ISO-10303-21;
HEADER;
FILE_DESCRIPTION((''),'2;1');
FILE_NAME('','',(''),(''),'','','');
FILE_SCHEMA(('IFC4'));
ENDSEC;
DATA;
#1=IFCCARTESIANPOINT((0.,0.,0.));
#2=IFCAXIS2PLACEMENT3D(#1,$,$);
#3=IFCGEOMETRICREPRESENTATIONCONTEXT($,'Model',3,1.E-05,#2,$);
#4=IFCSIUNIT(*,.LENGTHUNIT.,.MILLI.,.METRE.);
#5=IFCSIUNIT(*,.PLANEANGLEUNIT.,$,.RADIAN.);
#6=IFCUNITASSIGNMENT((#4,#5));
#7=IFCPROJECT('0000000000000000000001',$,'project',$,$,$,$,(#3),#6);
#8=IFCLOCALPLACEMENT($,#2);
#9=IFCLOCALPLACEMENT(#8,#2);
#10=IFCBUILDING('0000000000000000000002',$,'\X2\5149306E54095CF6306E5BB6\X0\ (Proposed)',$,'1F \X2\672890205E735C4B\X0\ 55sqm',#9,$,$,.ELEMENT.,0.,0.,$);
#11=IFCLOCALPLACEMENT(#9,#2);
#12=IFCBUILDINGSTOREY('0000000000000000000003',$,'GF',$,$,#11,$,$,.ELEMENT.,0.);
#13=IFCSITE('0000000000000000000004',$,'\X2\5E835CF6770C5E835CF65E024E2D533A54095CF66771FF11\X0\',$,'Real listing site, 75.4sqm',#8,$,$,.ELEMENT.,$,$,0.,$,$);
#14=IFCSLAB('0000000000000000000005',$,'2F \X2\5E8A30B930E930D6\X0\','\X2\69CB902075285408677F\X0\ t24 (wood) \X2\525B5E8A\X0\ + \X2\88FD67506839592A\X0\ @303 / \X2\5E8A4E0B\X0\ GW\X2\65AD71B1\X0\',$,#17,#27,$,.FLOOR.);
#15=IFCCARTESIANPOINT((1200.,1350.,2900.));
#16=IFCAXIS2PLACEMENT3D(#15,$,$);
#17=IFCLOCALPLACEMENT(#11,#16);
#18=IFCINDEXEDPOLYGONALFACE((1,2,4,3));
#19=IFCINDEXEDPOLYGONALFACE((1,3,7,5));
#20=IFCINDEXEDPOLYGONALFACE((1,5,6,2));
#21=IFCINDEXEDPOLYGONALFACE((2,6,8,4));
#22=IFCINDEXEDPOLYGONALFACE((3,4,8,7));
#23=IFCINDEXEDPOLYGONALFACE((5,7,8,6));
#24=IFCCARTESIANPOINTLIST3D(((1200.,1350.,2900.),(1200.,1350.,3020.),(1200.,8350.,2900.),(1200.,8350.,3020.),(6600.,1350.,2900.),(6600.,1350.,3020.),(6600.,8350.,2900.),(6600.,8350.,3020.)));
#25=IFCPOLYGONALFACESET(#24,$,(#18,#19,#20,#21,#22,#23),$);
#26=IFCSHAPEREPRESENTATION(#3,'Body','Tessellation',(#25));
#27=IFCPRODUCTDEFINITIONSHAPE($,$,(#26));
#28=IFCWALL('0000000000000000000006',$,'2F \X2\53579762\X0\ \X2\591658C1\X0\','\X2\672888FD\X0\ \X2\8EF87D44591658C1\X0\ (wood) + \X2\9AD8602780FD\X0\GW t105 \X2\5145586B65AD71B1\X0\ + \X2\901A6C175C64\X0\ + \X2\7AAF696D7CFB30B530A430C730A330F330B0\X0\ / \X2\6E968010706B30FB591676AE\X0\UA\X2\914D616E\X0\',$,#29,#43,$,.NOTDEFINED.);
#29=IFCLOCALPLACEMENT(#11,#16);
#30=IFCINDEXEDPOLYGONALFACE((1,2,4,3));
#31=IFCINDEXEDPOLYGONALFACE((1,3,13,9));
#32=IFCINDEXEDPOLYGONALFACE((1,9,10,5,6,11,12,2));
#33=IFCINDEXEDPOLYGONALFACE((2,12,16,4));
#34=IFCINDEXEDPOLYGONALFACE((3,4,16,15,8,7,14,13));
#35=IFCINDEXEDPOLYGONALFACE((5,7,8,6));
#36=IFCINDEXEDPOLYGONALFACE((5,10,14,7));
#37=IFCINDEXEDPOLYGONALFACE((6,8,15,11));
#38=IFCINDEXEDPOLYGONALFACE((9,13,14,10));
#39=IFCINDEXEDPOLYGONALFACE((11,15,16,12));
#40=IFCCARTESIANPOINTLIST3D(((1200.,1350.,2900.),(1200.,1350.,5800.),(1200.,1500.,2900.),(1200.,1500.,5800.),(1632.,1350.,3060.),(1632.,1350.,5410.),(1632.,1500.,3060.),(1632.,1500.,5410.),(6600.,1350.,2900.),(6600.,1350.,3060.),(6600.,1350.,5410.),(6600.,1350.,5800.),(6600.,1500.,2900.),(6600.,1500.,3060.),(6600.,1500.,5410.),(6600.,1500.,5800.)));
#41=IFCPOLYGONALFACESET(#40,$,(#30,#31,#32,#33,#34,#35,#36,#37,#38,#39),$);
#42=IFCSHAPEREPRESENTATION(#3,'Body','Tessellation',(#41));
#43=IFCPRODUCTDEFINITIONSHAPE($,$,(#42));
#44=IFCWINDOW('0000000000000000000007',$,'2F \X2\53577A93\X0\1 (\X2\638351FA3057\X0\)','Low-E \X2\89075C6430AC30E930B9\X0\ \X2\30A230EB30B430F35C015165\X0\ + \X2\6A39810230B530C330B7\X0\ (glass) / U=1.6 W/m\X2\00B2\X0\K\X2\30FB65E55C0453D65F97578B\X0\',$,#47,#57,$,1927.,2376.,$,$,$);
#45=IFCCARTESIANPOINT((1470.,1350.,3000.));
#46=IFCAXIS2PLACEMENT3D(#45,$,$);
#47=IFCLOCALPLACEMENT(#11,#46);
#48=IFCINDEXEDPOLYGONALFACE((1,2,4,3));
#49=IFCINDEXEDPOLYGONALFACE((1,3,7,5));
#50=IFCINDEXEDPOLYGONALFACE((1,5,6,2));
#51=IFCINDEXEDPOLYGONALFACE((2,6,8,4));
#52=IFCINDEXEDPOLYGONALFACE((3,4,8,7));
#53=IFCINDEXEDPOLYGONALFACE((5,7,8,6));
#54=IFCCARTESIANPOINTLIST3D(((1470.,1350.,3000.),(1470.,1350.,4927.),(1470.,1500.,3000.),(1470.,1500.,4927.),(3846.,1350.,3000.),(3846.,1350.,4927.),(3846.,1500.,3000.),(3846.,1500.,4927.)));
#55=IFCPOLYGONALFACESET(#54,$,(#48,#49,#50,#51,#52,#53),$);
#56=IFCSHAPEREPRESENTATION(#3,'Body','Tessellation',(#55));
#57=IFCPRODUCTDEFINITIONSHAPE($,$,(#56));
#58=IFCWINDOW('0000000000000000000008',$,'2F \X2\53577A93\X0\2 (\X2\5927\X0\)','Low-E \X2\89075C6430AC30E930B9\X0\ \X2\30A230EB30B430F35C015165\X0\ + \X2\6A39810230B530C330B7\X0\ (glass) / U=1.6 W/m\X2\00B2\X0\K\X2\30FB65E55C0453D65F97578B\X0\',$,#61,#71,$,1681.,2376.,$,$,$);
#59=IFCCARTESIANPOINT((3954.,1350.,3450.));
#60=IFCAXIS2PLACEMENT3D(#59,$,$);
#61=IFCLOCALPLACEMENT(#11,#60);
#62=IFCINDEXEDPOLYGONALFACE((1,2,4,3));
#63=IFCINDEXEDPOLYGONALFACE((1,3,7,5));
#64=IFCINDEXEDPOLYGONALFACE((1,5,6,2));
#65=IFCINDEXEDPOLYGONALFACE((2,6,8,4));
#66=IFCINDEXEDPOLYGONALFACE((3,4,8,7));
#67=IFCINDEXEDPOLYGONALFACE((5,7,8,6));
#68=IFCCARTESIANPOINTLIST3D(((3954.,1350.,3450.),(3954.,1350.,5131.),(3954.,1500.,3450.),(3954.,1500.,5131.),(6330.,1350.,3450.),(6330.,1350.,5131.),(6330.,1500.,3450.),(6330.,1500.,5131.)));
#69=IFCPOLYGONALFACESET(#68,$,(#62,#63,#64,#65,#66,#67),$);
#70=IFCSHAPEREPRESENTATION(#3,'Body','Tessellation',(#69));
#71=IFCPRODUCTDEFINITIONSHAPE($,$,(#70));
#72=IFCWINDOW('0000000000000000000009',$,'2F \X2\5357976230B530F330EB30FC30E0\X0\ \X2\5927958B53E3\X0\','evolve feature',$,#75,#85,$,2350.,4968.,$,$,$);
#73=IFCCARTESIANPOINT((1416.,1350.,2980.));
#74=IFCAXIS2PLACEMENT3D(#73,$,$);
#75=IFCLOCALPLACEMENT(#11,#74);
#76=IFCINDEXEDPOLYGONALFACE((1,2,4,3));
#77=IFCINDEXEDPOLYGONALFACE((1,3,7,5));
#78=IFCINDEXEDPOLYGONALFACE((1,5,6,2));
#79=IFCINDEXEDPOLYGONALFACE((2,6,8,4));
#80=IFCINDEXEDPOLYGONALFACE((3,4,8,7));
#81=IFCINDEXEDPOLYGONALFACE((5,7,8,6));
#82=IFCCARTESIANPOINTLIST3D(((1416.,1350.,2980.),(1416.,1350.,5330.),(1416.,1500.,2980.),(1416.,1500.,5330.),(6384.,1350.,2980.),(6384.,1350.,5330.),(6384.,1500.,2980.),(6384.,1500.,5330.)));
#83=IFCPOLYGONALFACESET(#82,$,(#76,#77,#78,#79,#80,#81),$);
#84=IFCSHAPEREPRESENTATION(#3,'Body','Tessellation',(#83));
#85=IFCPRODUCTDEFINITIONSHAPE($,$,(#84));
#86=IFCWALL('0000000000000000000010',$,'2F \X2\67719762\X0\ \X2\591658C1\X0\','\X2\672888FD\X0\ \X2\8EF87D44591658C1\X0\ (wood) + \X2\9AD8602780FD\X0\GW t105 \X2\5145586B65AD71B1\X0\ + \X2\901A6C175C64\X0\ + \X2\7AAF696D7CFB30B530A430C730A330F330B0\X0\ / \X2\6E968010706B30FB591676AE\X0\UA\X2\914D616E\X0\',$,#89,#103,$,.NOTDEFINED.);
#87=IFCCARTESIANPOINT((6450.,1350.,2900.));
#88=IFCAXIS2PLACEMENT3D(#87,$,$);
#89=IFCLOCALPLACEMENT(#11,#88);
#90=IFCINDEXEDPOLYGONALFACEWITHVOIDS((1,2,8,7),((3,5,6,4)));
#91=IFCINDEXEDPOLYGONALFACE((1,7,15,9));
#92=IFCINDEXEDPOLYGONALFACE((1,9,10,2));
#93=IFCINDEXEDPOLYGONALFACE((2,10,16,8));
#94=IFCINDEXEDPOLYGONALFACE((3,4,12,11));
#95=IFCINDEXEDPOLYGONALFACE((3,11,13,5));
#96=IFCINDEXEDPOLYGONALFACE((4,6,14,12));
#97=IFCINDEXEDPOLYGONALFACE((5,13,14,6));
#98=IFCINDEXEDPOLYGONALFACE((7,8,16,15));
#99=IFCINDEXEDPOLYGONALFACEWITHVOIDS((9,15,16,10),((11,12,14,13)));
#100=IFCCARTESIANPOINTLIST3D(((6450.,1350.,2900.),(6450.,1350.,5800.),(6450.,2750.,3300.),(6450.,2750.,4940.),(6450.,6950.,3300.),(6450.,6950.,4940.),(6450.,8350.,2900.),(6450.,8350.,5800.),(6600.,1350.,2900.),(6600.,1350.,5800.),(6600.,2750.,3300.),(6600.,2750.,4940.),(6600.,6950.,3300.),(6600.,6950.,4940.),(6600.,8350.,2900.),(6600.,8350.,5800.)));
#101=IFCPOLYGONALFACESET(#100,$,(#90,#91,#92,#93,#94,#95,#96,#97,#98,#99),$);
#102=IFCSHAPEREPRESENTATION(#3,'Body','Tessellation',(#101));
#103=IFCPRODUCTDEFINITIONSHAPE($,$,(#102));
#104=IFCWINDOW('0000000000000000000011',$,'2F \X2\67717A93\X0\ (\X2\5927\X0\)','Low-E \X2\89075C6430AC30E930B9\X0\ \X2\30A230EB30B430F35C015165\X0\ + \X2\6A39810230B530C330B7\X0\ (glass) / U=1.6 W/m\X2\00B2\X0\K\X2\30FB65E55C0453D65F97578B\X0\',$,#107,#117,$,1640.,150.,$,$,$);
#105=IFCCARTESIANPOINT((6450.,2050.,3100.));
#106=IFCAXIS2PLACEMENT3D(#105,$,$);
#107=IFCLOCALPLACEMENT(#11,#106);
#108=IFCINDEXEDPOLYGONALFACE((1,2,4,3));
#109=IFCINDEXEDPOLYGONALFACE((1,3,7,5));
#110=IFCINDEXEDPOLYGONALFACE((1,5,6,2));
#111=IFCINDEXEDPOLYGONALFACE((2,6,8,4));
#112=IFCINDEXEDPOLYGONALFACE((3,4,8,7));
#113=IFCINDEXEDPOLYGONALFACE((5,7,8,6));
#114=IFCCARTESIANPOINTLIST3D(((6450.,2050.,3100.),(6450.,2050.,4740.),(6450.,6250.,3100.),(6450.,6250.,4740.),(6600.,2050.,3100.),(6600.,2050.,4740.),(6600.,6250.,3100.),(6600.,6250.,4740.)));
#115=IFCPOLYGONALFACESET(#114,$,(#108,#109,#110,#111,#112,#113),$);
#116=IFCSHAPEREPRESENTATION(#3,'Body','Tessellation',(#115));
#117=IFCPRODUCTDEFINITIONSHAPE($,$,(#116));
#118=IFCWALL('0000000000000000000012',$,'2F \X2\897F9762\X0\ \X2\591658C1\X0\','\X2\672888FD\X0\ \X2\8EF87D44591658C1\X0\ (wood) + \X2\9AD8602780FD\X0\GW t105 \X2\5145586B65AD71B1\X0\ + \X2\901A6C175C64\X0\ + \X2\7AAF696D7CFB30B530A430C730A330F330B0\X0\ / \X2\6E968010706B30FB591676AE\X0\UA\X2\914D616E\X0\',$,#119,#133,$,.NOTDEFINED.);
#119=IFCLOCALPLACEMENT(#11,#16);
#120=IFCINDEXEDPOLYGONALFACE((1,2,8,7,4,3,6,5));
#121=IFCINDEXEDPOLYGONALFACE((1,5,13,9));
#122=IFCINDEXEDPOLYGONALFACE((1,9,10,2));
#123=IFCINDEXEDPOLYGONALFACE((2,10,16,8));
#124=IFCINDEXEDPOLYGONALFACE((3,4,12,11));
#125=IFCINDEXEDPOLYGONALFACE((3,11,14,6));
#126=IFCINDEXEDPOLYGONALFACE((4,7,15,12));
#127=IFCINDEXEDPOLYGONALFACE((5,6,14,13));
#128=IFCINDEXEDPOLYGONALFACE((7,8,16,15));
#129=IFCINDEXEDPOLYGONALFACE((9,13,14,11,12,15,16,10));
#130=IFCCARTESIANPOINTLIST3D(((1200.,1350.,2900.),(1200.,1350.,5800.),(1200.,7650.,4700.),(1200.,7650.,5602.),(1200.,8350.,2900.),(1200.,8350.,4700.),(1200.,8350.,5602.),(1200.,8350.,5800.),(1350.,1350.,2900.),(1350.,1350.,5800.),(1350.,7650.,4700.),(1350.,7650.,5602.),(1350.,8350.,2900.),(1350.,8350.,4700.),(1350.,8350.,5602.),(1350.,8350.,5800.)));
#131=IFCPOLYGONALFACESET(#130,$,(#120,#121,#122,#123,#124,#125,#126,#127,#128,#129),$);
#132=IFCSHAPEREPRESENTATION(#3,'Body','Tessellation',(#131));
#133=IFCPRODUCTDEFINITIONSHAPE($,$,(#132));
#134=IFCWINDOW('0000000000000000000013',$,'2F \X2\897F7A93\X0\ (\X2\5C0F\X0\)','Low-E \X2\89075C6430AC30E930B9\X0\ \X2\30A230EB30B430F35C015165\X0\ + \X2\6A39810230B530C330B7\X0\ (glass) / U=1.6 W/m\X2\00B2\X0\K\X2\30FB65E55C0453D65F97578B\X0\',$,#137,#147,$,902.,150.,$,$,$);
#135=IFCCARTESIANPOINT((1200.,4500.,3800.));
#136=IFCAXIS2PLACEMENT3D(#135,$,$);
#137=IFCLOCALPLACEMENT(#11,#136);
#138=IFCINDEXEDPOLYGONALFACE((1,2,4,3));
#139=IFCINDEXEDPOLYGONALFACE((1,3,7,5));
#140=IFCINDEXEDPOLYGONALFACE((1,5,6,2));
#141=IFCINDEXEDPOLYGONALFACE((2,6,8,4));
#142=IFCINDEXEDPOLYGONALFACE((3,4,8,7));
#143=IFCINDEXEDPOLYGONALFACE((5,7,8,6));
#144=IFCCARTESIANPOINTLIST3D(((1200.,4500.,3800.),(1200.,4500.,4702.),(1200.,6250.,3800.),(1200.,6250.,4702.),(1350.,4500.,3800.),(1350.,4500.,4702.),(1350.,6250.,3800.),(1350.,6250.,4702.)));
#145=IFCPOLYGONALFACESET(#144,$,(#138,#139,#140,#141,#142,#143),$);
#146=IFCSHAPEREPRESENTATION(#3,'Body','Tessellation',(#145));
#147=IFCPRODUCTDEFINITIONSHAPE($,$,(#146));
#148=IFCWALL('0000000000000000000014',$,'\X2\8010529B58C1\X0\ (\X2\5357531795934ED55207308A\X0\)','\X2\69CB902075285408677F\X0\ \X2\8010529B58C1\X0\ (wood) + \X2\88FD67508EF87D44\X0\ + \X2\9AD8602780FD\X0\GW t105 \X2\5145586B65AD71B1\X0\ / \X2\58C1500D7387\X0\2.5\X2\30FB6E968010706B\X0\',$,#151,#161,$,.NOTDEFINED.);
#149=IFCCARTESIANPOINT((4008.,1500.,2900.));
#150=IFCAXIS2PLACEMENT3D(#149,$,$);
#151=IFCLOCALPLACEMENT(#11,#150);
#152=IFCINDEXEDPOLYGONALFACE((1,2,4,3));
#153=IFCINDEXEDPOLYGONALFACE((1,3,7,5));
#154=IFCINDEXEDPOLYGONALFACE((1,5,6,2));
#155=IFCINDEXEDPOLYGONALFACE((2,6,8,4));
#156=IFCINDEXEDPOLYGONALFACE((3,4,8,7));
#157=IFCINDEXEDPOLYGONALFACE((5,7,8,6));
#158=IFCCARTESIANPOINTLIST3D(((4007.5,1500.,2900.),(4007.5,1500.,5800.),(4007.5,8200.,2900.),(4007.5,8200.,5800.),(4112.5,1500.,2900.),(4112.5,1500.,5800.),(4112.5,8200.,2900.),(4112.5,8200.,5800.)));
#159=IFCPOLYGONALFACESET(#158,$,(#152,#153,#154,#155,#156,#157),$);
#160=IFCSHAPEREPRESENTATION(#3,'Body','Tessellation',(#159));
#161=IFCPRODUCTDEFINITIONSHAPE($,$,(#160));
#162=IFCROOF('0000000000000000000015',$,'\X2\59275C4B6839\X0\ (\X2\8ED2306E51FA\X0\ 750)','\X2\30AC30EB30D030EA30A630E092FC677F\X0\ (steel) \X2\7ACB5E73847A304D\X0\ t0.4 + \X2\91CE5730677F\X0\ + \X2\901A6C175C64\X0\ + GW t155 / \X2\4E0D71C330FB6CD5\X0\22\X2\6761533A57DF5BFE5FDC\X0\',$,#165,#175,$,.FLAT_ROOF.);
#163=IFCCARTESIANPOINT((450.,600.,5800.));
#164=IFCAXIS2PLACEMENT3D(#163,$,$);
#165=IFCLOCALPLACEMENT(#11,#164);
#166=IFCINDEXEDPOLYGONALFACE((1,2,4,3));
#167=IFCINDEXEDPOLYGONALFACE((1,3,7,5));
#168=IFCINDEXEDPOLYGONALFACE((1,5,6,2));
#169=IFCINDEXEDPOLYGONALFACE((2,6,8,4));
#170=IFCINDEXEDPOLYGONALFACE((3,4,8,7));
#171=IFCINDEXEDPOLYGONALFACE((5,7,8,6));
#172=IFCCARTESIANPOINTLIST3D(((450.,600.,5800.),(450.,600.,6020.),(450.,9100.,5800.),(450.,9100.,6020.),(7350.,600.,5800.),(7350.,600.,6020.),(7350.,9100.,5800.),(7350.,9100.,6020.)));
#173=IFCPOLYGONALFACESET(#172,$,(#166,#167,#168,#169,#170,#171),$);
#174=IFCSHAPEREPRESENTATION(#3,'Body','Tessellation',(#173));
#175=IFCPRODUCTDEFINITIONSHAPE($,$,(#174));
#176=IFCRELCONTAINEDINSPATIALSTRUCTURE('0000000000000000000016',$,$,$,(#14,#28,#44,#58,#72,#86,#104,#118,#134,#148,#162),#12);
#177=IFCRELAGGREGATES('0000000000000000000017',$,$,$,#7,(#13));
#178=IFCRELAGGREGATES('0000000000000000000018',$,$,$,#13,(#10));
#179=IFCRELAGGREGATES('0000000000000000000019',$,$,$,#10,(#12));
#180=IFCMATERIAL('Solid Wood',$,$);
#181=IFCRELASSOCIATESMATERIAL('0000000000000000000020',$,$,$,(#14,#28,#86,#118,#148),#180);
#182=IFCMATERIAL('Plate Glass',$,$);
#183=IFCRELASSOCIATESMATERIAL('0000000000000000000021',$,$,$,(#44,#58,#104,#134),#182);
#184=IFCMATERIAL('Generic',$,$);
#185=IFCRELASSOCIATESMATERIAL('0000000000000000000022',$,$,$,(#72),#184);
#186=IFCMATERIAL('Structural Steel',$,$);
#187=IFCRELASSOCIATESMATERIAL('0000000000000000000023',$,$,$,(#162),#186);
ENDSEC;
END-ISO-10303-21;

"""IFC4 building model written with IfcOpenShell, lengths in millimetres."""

from ifc_helpers import new_model, si_unit, frame, frame_2d, origin, place, context, project, spatial, rectangle, extrude, material, element, fill, save


model = new_model("IFC4")

# Units and contexts
model_context = context("Model", 3, precision=1e-05, world=origin())
ifc_project = project(units=[si_unit("LENGTHUNIT", "METRE", prefix="MILLI"), si_unit("PLANEANGLEUNIT", "RADIAN")], contexts=[model_context])

# Site, building, storey
site_placement = place(None, origin())
site = spatial("IfcSite", under=ifc_project, at=site_placement, Name="広島県広島市中区吉島東１", ObjectType="Real listing site, 75.4sqm", CompositionType="ELEMENT", RefElevation=0.0)
building_placement = place(site_placement, origin())
building = spatial("IfcBuilding", under=site, at=building_placement, Name="光の吉島の家 (Proposed)", ObjectType="1F 木造平屋 55sqm", CompositionType="ELEMENT", ElevationOfRefHeight=0.0, ElevationOfTerrain=0.0)
storey_placement = place(building_placement, origin())
storey = spatial("IfcBuildingStorey", under=building, at=storey_placement, Name="GF", CompositionType="ELEMENT", Elevation=0.0)

# Slab
ifc_material_1 = material(Name="Solid Wood")
slab_placement = place(storey_placement, frame((1200.0, 1350.0, 2900.0)))
element("IfcSlab", 1, at=slab_placement, inside=storey, material=ifc_material_1, Name="2F 床スラブ", Description="構造用合板 t24 (wood) 剛床 + 製材根太 @303 / 床下 GW断熱", PredefinedType="FLOOR", context=model_context, shape_type="SweptSolid", body=[
    extrude(rectangle(XDim=5400.0, YDim=7000.0, at=frame_2d((2700.0, 3500.0))), frame((1200.0, 1350.0, 2900.0)), (0.0, 0.0, 1.0), 120.0),
])

# Wall, openings, windows
wall_1_placement = place(storey_placement, frame((1200.0, 1350.0, 2900.0)))
wall_1 = element("IfcWall", 2, at=wall_1_placement, inside=storey, material=ifc_material_1, Name="2F 南面 外壁", Description="木製 軸組外壁 (wood) + 高性能GW t105 充填断熱 + 通気層 + 窯業系サイディング / 準耐火・外皮UA配慮", PredefinedType="NOTDEFINED", context=model_context, shape_type="SweptSolid", body=[
    extrude(rectangle(XDim=5400.0, YDim=150.0, at=frame_2d((2700.0, 75.0))), frame((1200.0, 1350.0, 2900.0)), (0.0, 0.0, 1.0), 2900.0),
])
opening_1_placement = place(storey_placement, frame((1470.0, 1350.0, 3000.0)))
opening_1 = element("IfcOpeningElement", 3, at=opening_1_placement, cuts=wall_1, PredefinedType="NOTDEFINED", context=model_context, shape_type="SweptSolid", body=[
    extrude(rectangle(XDim=2376.0, YDim=150.0, at=frame_2d((1188.0, 75.0))), frame((1470.0, 1350.0, 3000.0)), (0.0, 0.0, 1.0), 1927.0),
])
opening_2_placement = place(storey_placement, frame((3954.0, 1350.0, 3450.0)))
opening_2 = element("IfcOpeningElement", 4, at=opening_2_placement, cuts=wall_1, PredefinedType="NOTDEFINED", context=model_context, shape_type="SweptSolid", body=[
    extrude(rectangle(XDim=2376.0, YDim=150.0, at=frame_2d((1188.0, 75.0))), frame((3954.0, 1350.0, 3450.0)), (0.0, 0.0, 1.0), 1681.0),
])
opening_3_placement = place(storey_placement, frame((1416.0, 1350.0, 2980.0)))
opening_3 = element("IfcOpeningElement", 5, at=opening_3_placement, cuts=wall_1, PredefinedType="NOTDEFINED", context=model_context, shape_type="SweptSolid", body=[
    extrude(rectangle(XDim=4968.0, YDim=150.0, at=frame_2d((2484.0, 75.0))), frame((1416.0, 1350.0, 2980.0)), (0.0, 0.0, 1.0), 2350.0),
])
ifc_material_2 = material(Name="Plate Glass")
window_1_placement = place(storey_placement, frame((1470.0, 1350.0, 3000.0)))
window_1 = element("IfcWindow", 6, at=window_1_placement, inside=storey, material=ifc_material_2, Name="2F 南窓1 (掃出し)", Description="Low-E 複層ガラス アルゴン封入 + 樹脂サッシ (glass) / U=1.6 W/m²K・日射取得型", OverallHeight=1927.0, OverallWidth=2376.0, context=model_context, shape_type="SweptSolid", body=[
    extrude(rectangle(XDim=2376.0, YDim=150.0, at=frame_2d((1188.0, 75.0))), frame((1470.0, 1350.0, 3000.0)), (0.0, 0.0, 1.0), 1927.0),
])
fill(opening_1, window_1)
window_2_placement = place(storey_placement, frame((3954.0, 1350.0, 3450.0)))
window_2 = element("IfcWindow", 7, at=window_2_placement, inside=storey, material=ifc_material_2, Name="2F 南窓2 (大)", Description="Low-E 複層ガラス アルゴン封入 + 樹脂サッシ (glass) / U=1.6 W/m²K・日射取得型", OverallHeight=1681.0, OverallWidth=2376.0, context=model_context, shape_type="SweptSolid", body=[
    extrude(rectangle(XDim=2376.0, YDim=150.0, at=frame_2d((1188.0, 75.0))), frame((3954.0, 1350.0, 3450.0)), (0.0, 0.0, 1.0), 1681.0),
])
fill(opening_2, window_2)
ifc_material_3 = material(Name="Generic")
window_3_placement = place(storey_placement, frame((1416.0, 1350.0, 2980.0)))
window_3 = element("IfcWindow", 8, at=window_3_placement, inside=storey, material=ifc_material_3, Name="2F 南面サンルーム 大開口", Description="evolve feature", OverallHeight=2350.0, OverallWidth=4968.0, context=model_context, shape_type="SweptSolid", body=[
    extrude(rectangle(XDim=4968.0, YDim=150.0, at=frame_2d((2484.0, 75.0))), frame((1416.0, 1350.0, 2980.0)), (0.0, 0.0, 1.0), 2350.0),
])
fill(opening_3, window_3)

# Walls, openings, windows
wall_2_placement = place(storey_placement, frame((6450.0, 1350.0, 2900.0)))
wall_2 = element("IfcWall", 9, at=wall_2_placement, inside=storey, material=ifc_material_1, Name="2F 東面 外壁", Description="木製 軸組外壁 (wood) + 高性能GW t105 充填断熱 + 通気層 + 窯業系サイディング / 準耐火・外皮UA配慮", PredefinedType="NOTDEFINED", context=model_context, shape_type="SweptSolid", body=[
    extrude(rectangle(XDim=150.0, YDim=7000.0, at=frame_2d((75.0, 3500.0))), frame((6450.0, 1350.0, 2900.0)), (0.0, 0.0, 1.0), 2900.0),
])
opening_4_placement = place(storey_placement, frame((6450.0, 2050.0, 3100.0)))
opening_4 = element("IfcOpeningElement", 10, at=opening_4_placement, cuts=wall_2, PredefinedType="NOTDEFINED", context=model_context, shape_type="SweptSolid", body=[
    extrude(rectangle(XDim=150.0, YDim=4200.0, at=frame_2d((75.0, 2100.0))), frame((6450.0, 2050.0, 3100.0)), (0.0, 0.0, 1.0), 1640.0),
])
window_4_placement = place(storey_placement, frame((6450.0, 2050.0, 3100.0)))
window_4 = element("IfcWindow", 11, at=window_4_placement, inside=storey, material=ifc_material_2, Name="2F 東窓 (大)", Description="Low-E 複層ガラス アルゴン封入 + 樹脂サッシ (glass) / U=1.6 W/m²K・日射取得型", OverallHeight=1640.0, OverallWidth=150.0, context=model_context, shape_type="SweptSolid", body=[
    extrude(rectangle(XDim=150.0, YDim=4200.0, at=frame_2d((75.0, 2100.0))), frame((6450.0, 2050.0, 3100.0)), (0.0, 0.0, 1.0), 1640.0),
])
fill(opening_4, window_4)
wall_3_placement = place(storey_placement, frame((1200.0, 1350.0, 2900.0)))
wall_3 = element("IfcWall", 12, at=wall_3_placement, inside=storey, material=ifc_material_1, Name="2F 西面 外壁", Description="木製 軸組外壁 (wood) + 高性能GW t105 充填断熱 + 通気層 + 窯業系サイディング / 準耐火・外皮UA配慮", PredefinedType="NOTDEFINED", context=model_context, shape_type="SweptSolid", body=[
    extrude(rectangle(XDim=150.0, YDim=7000.0, at=frame_2d((75.0, 3500.0))), frame((1200.0, 1350.0, 2900.0)), (0.0, 0.0, 1.0), 2900.0),
])
opening_5_placement = place(storey_placement, frame((1200.0, 4500.0, 3800.0)))
opening_5 = element("IfcOpeningElement", 13, at=opening_5_placement, cuts=wall_3, PredefinedType="NOTDEFINED", context=model_context, shape_type="SweptSolid", body=[
    extrude(rectangle(XDim=150.0, YDim=1750.0, at=frame_2d((75.0, 875.0))), frame((1200.0, 4500.0, 3800.0)), (0.0, 0.0, 1.0), 902.0),
])
window_5_placement = place(storey_placement, frame((1200.0, 4500.0, 3800.0)))
window_5 = element("IfcWindow", 14, at=window_5_placement, inside=storey, material=ifc_material_2, Name="2F 西窓 (小)", Description="Low-E 複層ガラス アルゴン封入 + 樹脂サッシ (glass) / U=1.6 W/m²K・日射取得型", OverallHeight=902.0, OverallWidth=150.0, context=model_context, shape_type="SweptSolid", body=[
    extrude(rectangle(XDim=150.0, YDim=1750.0, at=frame_2d((75.0, 875.0))), frame((1200.0, 4500.0, 3800.0)), (0.0, 0.0, 1.0), 902.0),
])
fill(opening_5, window_5)

# Wall
wall_4_placement = place(storey_placement, frame((4008.0, 1500.0, 2900.0)))
element("IfcWall", 15, at=wall_4_placement, inside=storey, material=ifc_material_1, Name="耐力壁 (南北間仕切り)", Description="構造用合板 耐力壁 (wood) + 製材軸組 + 高性能GW t105 充填断熱 / 壁倍率2.5・準耐火", PredefinedType="NOTDEFINED", context=model_context, shape_type="SweptSolid", body=[
    extrude(rectangle(XDim=105.0, YDim=6700.0, at=frame_2d((52.0, 3350.0))), frame((4008.0, 1500.0, 2900.0)), (0.0, 0.0, 1.0), 2900.0),
])

# Roof
ifc_material_4 = material(Name="Structural Steel")
roof_placement = place(storey_placement, frame((450.0, 600.0, 5800.0)))
element("IfcRoof", 16, at=roof_placement, inside=storey, material=ifc_material_4, Name="大屋根 (軒の出 750)", Description="ガルバリウム鋼板 (steel) 立平葺き t0.4 + 野地板 + 通気層 + GW t155 / 不燃・法22条区域対応", PredefinedType="FLAT_ROOF", context=model_context, shape_type="SweptSolid", body=[
    extrude(rectangle(XDim=6900.0, YDim=8500.0, at=frame_2d((3450.0, 4250.0))), frame((450.0, 600.0, 5800.0)), (0.0, 0.0, 1.0), 220.0),
])

save(model, "model.ifc")
